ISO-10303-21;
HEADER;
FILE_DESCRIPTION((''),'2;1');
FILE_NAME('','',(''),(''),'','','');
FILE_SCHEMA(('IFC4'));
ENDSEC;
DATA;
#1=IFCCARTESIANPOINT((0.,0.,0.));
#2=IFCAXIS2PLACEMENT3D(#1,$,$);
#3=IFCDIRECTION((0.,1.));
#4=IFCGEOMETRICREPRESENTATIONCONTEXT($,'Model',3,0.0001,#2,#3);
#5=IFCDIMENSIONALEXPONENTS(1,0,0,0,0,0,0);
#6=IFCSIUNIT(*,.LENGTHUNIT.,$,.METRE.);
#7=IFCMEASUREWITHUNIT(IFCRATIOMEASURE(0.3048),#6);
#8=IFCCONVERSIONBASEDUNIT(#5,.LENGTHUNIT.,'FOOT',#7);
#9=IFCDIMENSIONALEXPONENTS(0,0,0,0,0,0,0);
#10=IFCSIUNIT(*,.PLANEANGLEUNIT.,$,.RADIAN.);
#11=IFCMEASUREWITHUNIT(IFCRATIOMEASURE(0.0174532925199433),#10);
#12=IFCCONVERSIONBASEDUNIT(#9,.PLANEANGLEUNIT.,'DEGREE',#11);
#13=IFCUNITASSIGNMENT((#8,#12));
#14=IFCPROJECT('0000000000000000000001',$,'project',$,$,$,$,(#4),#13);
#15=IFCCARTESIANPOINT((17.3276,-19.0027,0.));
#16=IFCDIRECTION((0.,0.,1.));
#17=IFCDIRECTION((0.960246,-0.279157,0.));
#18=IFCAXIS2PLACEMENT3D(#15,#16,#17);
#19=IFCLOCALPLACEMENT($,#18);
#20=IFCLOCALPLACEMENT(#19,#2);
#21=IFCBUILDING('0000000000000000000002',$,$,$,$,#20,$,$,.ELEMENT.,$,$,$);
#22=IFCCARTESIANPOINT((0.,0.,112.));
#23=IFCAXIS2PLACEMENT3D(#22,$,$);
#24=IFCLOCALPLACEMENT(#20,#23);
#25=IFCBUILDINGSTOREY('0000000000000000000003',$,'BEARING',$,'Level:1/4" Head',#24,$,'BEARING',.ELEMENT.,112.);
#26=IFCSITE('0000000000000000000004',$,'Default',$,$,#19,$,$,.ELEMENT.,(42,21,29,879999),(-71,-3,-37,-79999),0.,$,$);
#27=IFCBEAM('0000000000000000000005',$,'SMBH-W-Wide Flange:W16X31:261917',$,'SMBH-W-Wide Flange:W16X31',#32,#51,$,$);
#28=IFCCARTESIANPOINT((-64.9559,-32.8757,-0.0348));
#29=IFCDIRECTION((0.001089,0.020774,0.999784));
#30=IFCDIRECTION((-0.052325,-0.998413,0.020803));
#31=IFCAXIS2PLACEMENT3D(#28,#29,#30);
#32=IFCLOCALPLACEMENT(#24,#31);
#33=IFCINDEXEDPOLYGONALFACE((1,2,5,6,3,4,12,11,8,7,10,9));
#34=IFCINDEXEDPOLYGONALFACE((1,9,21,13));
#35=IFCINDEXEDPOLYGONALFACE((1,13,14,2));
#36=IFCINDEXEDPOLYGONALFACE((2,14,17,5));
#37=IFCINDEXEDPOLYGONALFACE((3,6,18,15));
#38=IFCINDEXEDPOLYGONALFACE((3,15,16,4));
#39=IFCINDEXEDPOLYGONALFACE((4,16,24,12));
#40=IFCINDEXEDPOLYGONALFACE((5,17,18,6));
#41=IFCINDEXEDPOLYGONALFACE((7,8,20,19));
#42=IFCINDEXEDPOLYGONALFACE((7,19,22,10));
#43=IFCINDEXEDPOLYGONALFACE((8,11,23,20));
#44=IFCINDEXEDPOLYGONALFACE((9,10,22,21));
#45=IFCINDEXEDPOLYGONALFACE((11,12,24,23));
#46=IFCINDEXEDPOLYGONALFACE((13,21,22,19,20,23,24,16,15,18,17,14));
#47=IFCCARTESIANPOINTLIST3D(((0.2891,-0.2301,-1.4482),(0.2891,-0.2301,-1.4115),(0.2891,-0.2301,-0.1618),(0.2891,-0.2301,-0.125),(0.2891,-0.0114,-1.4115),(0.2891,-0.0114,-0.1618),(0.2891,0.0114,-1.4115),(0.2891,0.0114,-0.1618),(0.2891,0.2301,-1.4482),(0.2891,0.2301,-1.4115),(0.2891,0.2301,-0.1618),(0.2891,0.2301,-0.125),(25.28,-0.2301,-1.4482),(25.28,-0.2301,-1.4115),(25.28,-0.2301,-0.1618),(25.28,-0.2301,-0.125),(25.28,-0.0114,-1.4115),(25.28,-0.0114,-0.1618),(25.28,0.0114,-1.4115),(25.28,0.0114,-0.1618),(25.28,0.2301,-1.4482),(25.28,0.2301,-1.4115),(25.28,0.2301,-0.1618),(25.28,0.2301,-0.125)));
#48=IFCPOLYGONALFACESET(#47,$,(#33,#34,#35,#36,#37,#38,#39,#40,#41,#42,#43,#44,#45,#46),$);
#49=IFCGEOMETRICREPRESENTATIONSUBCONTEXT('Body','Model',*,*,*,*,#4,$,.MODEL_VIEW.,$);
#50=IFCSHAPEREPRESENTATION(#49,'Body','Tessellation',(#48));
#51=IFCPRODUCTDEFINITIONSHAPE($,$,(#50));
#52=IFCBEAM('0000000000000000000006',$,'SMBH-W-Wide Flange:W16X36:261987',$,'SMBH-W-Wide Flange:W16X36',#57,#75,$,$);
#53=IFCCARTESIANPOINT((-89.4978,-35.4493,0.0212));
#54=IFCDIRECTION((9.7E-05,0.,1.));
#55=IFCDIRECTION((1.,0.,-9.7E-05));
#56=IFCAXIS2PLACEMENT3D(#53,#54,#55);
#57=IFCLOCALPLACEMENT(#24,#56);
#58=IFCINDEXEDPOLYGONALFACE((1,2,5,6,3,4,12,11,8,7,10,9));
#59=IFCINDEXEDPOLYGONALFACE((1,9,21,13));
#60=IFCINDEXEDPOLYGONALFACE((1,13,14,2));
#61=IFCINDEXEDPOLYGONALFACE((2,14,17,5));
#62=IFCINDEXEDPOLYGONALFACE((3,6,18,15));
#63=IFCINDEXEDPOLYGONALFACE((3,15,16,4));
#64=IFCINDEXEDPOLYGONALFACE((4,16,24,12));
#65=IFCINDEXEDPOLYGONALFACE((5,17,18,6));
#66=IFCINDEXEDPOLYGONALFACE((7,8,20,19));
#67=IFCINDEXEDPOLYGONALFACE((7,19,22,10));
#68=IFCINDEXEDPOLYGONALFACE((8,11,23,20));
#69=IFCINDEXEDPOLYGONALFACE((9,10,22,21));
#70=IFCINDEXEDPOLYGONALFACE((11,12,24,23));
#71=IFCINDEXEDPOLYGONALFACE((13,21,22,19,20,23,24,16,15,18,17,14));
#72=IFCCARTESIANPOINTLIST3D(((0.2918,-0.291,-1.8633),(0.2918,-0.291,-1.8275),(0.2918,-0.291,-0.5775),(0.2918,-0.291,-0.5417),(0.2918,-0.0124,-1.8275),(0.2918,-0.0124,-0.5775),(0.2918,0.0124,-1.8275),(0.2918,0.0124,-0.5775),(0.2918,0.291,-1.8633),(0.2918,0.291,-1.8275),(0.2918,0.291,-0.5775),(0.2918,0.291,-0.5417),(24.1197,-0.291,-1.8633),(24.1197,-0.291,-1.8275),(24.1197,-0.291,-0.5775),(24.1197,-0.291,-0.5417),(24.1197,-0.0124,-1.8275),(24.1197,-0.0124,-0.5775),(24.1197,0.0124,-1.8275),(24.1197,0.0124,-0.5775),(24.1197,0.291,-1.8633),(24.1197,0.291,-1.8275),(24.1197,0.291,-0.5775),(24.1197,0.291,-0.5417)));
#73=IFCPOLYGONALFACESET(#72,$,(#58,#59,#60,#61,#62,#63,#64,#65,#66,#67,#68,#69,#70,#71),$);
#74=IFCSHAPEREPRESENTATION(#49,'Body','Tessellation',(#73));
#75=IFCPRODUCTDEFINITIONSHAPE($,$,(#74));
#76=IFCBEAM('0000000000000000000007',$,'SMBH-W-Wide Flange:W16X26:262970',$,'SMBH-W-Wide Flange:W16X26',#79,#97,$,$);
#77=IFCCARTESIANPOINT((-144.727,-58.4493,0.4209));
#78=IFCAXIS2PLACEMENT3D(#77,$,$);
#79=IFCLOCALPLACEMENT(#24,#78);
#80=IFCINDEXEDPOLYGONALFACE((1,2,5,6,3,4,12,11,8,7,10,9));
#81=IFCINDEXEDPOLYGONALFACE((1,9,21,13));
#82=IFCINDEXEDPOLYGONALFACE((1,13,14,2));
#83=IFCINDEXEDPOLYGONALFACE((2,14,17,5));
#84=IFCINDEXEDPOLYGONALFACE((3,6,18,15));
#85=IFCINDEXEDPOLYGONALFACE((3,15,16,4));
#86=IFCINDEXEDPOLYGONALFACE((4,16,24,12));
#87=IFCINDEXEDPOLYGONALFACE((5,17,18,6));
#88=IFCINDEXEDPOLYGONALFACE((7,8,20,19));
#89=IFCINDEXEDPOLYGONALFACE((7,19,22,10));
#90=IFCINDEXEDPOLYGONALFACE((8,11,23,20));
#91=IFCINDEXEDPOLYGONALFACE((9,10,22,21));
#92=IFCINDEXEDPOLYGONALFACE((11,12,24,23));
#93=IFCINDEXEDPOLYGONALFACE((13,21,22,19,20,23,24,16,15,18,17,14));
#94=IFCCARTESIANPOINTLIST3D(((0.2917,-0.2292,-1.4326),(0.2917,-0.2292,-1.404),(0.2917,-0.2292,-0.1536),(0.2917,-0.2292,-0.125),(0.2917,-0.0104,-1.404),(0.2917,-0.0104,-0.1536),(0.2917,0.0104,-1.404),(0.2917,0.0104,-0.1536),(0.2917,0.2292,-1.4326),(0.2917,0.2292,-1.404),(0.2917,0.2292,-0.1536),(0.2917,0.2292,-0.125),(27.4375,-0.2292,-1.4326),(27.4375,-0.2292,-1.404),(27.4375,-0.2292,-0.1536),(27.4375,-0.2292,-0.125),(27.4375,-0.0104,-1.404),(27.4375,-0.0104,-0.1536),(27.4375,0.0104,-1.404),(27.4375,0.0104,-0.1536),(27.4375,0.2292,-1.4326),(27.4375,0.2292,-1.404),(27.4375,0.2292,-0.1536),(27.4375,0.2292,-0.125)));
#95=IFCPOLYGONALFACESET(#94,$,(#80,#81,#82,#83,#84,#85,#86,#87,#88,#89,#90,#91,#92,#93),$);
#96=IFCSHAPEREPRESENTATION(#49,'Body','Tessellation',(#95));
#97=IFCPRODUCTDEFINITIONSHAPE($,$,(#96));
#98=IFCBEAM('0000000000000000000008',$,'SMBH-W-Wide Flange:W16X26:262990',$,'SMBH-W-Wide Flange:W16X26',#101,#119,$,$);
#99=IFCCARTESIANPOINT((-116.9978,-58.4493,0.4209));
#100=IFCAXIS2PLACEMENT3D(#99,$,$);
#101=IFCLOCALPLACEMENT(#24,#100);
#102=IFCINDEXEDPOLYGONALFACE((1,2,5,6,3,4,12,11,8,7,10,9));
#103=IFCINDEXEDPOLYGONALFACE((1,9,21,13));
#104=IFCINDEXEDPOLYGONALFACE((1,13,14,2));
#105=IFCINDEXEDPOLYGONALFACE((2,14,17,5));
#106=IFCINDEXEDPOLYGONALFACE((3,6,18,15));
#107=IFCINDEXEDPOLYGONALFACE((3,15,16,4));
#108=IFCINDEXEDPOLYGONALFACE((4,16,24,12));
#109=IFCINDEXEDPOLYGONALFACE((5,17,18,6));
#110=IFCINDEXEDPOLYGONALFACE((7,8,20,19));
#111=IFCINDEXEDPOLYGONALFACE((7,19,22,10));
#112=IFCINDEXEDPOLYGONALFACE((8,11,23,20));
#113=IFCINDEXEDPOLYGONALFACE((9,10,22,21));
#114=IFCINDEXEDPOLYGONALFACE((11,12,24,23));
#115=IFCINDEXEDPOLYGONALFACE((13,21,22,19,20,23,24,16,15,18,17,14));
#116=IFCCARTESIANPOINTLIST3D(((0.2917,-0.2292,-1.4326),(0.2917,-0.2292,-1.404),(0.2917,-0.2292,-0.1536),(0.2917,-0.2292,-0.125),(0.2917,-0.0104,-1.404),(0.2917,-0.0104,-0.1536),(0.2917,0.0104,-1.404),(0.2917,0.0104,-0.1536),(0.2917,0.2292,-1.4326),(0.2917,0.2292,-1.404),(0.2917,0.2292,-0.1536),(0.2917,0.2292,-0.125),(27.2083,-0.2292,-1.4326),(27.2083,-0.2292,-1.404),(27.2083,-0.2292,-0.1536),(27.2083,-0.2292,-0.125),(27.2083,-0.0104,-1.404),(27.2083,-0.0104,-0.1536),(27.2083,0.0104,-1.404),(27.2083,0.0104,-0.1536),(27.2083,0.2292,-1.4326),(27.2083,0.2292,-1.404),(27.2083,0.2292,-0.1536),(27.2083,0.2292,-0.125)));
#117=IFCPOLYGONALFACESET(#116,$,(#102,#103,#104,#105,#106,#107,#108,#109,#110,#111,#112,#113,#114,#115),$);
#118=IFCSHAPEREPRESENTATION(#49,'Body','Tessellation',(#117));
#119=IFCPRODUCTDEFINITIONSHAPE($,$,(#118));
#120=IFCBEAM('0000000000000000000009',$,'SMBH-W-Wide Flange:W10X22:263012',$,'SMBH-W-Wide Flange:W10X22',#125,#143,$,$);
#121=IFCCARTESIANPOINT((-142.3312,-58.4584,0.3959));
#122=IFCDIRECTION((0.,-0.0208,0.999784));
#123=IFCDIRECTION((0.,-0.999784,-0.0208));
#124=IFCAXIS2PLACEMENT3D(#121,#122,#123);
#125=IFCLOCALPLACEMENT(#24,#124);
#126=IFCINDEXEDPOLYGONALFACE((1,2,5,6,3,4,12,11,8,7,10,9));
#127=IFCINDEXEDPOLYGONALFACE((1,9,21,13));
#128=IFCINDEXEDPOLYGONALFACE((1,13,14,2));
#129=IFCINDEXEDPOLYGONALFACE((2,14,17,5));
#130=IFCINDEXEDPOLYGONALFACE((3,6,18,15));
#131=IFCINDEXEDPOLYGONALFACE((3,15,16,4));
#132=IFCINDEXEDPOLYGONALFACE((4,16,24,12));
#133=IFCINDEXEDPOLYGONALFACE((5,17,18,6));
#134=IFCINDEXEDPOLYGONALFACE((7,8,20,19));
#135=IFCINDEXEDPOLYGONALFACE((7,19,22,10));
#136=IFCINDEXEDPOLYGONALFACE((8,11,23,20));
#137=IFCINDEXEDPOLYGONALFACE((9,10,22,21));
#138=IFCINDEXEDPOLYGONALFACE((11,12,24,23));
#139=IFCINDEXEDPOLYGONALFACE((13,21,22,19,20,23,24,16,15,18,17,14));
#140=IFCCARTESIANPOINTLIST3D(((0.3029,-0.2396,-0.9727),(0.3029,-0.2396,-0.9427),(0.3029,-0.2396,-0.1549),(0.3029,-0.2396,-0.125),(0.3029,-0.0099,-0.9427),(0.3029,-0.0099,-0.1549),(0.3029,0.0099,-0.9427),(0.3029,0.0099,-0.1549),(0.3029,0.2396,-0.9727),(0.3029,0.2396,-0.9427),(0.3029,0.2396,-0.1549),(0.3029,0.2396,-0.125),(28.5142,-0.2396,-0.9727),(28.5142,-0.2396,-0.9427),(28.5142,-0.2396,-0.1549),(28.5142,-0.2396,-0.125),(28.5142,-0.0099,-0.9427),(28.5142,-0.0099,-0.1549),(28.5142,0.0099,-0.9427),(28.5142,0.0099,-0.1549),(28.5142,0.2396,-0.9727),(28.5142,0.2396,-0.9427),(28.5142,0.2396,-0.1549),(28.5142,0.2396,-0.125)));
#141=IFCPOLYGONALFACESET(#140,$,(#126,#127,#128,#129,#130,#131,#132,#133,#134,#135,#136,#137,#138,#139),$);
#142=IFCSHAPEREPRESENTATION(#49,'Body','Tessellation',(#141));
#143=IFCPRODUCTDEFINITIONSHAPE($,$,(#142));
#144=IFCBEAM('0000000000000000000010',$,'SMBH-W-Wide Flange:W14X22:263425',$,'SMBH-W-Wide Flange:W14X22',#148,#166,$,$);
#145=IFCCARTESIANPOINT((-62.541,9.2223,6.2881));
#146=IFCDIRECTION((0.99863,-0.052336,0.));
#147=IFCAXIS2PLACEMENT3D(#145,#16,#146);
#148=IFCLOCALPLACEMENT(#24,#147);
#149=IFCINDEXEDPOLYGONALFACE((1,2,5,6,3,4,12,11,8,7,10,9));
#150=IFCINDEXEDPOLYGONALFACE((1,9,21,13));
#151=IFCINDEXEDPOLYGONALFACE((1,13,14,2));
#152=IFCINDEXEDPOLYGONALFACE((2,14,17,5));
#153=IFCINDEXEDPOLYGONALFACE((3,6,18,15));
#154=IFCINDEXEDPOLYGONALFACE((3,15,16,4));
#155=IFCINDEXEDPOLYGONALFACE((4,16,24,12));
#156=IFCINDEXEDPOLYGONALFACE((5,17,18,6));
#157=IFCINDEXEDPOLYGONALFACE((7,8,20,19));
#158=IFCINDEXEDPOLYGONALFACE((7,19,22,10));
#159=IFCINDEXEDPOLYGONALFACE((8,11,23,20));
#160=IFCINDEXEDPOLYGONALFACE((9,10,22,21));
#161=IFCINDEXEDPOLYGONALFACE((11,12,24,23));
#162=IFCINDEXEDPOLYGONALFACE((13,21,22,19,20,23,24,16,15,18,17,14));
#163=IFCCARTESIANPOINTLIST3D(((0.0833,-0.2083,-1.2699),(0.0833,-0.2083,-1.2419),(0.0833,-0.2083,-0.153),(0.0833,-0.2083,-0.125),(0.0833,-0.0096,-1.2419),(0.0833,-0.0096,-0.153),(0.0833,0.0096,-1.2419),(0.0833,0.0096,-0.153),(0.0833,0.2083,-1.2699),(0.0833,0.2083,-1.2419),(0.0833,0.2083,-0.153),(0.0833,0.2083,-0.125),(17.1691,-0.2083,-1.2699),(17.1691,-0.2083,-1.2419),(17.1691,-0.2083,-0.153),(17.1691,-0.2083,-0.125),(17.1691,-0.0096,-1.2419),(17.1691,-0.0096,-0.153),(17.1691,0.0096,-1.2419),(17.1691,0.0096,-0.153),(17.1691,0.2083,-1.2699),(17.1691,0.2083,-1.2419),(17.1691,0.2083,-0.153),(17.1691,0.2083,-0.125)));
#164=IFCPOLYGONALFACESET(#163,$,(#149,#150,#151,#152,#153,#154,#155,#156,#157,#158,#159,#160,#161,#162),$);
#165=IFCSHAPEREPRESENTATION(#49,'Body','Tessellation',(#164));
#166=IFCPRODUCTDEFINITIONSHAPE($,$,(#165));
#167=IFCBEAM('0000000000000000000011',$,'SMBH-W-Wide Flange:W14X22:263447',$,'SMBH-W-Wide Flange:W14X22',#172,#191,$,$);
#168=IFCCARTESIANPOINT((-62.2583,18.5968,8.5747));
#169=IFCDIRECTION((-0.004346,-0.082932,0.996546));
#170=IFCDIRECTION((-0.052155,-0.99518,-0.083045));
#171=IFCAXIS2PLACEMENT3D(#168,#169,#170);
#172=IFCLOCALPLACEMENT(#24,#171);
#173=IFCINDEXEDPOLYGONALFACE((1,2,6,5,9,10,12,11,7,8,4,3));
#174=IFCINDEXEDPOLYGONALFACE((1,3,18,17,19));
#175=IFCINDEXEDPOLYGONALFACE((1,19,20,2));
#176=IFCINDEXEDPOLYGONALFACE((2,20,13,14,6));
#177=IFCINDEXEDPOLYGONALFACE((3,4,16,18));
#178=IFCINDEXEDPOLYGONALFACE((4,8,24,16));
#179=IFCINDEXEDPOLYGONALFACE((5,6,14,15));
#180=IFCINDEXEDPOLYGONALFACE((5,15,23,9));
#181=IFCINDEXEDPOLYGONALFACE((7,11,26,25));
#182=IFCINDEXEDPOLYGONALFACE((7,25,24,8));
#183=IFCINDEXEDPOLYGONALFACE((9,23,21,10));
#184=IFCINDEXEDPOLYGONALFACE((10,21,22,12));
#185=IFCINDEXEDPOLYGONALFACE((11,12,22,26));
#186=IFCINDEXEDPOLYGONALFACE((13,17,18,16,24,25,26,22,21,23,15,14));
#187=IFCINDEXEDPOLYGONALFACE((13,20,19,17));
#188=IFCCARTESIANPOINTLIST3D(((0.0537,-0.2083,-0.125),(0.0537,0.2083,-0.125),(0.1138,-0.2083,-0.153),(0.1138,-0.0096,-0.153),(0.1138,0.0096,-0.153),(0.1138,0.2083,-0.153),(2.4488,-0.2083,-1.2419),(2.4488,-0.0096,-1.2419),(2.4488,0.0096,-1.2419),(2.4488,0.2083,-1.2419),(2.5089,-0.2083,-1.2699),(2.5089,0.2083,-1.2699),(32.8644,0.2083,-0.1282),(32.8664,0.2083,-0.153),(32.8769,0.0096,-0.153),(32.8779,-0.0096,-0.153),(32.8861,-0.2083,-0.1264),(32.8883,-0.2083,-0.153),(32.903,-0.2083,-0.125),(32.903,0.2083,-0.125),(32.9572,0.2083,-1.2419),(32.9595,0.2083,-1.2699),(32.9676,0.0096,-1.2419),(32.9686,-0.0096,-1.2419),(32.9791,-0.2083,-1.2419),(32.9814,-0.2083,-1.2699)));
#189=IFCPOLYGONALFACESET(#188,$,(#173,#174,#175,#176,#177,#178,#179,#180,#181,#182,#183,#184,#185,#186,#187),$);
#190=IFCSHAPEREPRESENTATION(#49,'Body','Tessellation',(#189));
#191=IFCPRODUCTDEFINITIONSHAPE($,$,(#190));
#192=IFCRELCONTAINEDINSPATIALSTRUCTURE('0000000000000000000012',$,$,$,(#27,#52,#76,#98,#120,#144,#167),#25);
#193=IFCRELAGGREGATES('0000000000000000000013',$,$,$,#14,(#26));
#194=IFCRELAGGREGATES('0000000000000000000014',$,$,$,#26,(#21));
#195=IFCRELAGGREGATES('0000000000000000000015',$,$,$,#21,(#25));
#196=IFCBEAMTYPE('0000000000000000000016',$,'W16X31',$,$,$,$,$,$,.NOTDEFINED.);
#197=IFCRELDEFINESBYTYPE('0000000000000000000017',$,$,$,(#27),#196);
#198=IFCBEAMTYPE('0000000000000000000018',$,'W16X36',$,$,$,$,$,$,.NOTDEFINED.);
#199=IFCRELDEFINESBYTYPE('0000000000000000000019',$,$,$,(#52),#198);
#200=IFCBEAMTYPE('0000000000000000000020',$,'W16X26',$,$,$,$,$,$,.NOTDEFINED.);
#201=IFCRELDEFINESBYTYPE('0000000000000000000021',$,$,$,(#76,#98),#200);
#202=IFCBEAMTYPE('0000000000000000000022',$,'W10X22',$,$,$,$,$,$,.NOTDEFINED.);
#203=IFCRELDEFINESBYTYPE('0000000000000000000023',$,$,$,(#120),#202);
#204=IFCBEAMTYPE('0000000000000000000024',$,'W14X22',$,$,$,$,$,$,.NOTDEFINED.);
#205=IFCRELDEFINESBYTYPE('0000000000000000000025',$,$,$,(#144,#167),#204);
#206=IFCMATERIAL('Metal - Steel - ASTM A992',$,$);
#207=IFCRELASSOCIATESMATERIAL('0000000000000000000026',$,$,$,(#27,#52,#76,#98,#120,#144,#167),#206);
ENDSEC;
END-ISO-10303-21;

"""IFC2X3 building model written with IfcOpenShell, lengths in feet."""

from ifc_helpers import new_model, entity, si_unit, converted_unit, direction, frame, frame_2d, origin, place, context, subcontext, project, spatial, polyline, i_section, outline, extrude, clip, halfspace, bounded_halfspace, material, type_object, element, save


model = new_model("IFC2X3")

# Units and contexts
model_context = context("Model", 3, precision=0.0001, world=origin(), true_north=direction((0.0, 1.0)))
body_context = subcontext(model_context, "Body", "Model", "MODEL_VIEW")
ifc_project = project(units=[converted_unit("LENGTHUNIT", "FOOT", entity("IfcRatioMeasure", 0.3048), si_unit("LENGTHUNIT", "METRE"), dimensions=[1, 0, 0, 0, 0, 0, 0]), converted_unit("PLANEANGLEUNIT", "DEGREE", entity("IfcRatioMeasure", 0.0174532925199433), si_unit("PLANEANGLEUNIT", "RADIAN"), dimensions=[0, 0, 0, 0, 0, 0, 0])], contexts=[model_context])

# Site, building, storey
site_placement = place(None, frame((17.3276, -19.0027, 0.0), z_axis=(0.0, 0.0, 1.0), x_axis=(0.960246, -0.279157, 0.0)))
site = spatial("IfcSite", under=ifc_project, at=site_placement, Name="Default", CompositionType="ELEMENT", RefLatitude=(42, 21, 29, 879999), RefLongitude=(-71, -3, -37, -79999), RefElevation=0.0)
building_placement = place(site_placement, origin())
building = spatial("IfcBuilding", under=site, at=building_placement, CompositionType="ELEMENT")
storey_placement = place(building_placement, frame((0.0, 0.0, 112.0)))
storey = spatial("IfcBuildingStorey", under=building, at=storey_placement, Name="BEARING", ObjectType="Level:1/4\" Head", LongName="BEARING", CompositionType="ELEMENT", Elevation=112.0)

# Beams
ifc_material_1 = material(Name="Metal - Steel - ASTM A992")
beam_type_1 = type_object("IfcBeamType", Name="W16X31", PredefinedType="NOTDEFINED")
beam_1_placement = place(storey_placement, frame((-64.9559, -32.8757, -0.0348), z_axis=(0.001089, 0.020774, 0.999784), x_axis=(-0.052325, -0.998413, 0.020803)))
element("IfcBeam", 1, at=beam_1_placement, inside=storey, type_object=beam_type_1, material=ifc_material_1, Name="SMBH-W-Wide Flange:W16X31:261917", ObjectType="SMBH-W-Wide Flange:W16X31", context=body_context, shape_type="SweptSolid", body=[
    extrude(i_section(OverallWidth=0.4603, OverallDepth=1.3232, WebThickness=0.0228, FlangeThickness=0.0368, at=frame_2d((0.0, 0.0), x_axis=(0.0, 1.0))), frame((0.2891, 0.0, -0.7866), z_axis=(1.0, 0.0, 0.0), x_axis=(0.0, 0.0, -1.0)), (0.0, 0.0, 1.0), 24.9909),
])
beam_type_2 = type_object("IfcBeamType", Name="W16X36", PredefinedType="NOTDEFINED")
beam_2_placement = place(storey_placement, frame((-89.4978, -35.4493, 0.0212), z_axis=(0.000097, 0.0, 1.0), x_axis=(1.0, 0.0, -0.000097)))
element("IfcBeam", 2, at=beam_2_placement, inside=storey, type_object=beam_type_2, material=ifc_material_1, Name="SMBH-W-Wide Flange:W16X36:261987", ObjectType="SMBH-W-Wide Flange:W16X36", context=body_context, shape_type="SweptSolid", body=[
    extrude(i_section(OverallWidth=0.582, OverallDepth=1.3216, WebThickness=0.0247, FlangeThickness=0.0358, at=frame_2d((0.0, 0.0), x_axis=(0.0, 1.0))), frame((0.2918, 0.0, -1.2025), z_axis=(1.0, 0.0, 0.0), x_axis=(0.0, 0.0, -1.0)), (0.0, 0.0, 1.0), 23.8279),
])
beam_type_3 = type_object("IfcBeamType", Name="W16X26", PredefinedType="NOTDEFINED")
beam_3_placement = place(storey_placement, frame((-144.727, -58.4493, 0.4209)))
element("IfcBeam", 3, at=beam_3_placement, inside=storey, type_object=beam_type_3, material=ifc_material_1, Name="SMBH-W-Wide Flange:W16X26:262970", ObjectType="SMBH-W-Wide Flange:W16X26", context=body_context, shape_type="SweptSolid", body=[
    extrude(i_section(OverallWidth=0.4583, OverallDepth=1.3076, WebThickness=0.0208, FlangeThickness=0.0286, at=frame_2d((0.0, 0.0), x_axis=(0.0, 1.0))), frame((0.2917, 0.0, -0.7788), z_axis=(1.0, 0.0, 0.0), x_axis=(0.0, 0.0, -1.0)), (0.0, 0.0, 1.0), 27.1458),
])
beam_4_placement = place(storey_placement, frame((-116.9978, -58.4493, 0.4209)))
element("IfcBeam", 4, at=beam_4_placement, inside=storey, type_object=beam_type_3, material=ifc_material_1, Name="SMBH-W-Wide Flange:W16X26:262990", ObjectType="SMBH-W-Wide Flange:W16X26", context=body_context, shape_type="SweptSolid", body=[
    extrude(i_section(OverallWidth=0.4583, OverallDepth=1.3076, WebThickness=0.0208, FlangeThickness=0.0286, at=frame_2d((0.0, 0.0), x_axis=(0.0, 1.0))), frame((0.2917, 0.0, -0.7788), z_axis=(1.0, 0.0, 0.0), x_axis=(0.0, 0.0, -1.0)), (0.0, 0.0, 1.0), 26.9167),
])
beam_type_4 = type_object("IfcBeamType", Name="W10X22", PredefinedType="NOTDEFINED")
beam_5_placement = place(storey_placement, frame((-142.3312, -58.4584, 0.3959), z_axis=(0.0, -0.0208, 0.999784), x_axis=(0.0, -0.999784, -0.0208)))
element("IfcBeam", 5, at=beam_5_placement, inside=storey, type_object=beam_type_4, material=ifc_material_1, Name="SMBH-W-Wide Flange:W10X22:263012", ObjectType="SMBH-W-Wide Flange:W10X22", context=body_context, shape_type="SweptSolid", body=[
    extrude(i_section(OverallWidth=0.4792, OverallDepth=0.8477, WebThickness=0.0199, FlangeThickness=0.0299, at=frame_2d((0.0, 0.0), x_axis=(0.0, 1.0))), frame((0.3029, 0.0, -0.5488), z_axis=(1.0, 0.0, 0.0), x_axis=(0.0, 0.0, -1.0)), (0.0, 0.0, 1.0), 28.2113),
])
beam_type_5 = type_object("IfcBeamType", Name="W14X22", PredefinedType="NOTDEFINED")
beam_6_placement = place(storey_placement, frame((-62.541, 9.2223, 6.2881), z_axis=(0.0, 0.0, 1.0), x_axis=(0.99863, -0.052336, 0.0)))
element("IfcBeam", 6, at=beam_6_placement, inside=storey, type_object=beam_type_5, material=ifc_material_1, Name="SMBH-W-Wide Flange:W14X22:263425", ObjectType="SMBH-W-Wide Flange:W14X22", context=body_context, shape_type="SweptSolid", body=[
    extrude(i_section(OverallWidth=0.4167, OverallDepth=1.1449, WebThickness=0.0192, FlangeThickness=0.028, at=frame_2d((0.0, 0.0), x_axis=(0.0, 1.0))), frame((0.0833, 0.0, -0.6974), z_axis=(1.0, 0.0, 0.0), x_axis=(0.0, 0.0, -1.0)), (0.0, 0.0, 1.0), 17.0857),
])
beam_7_placement = place(storey_placement, frame((-62.2583, 18.5968, 8.5747), z_axis=(-0.004346, -0.082932, 0.996546), x_axis=(-0.052155, -0.99518, -0.083045)))
element("IfcBeam", 7, at=beam_7_placement, inside=storey, type_object=beam_type_5, material=ifc_material_1, Name="SMBH-W-Wide Flange:W14X22:263447", ObjectType="SMBH-W-Wide Flange:W14X22", context=body_context, shape_type="SweptSolid", body=[
    clip(clip(clip(extrude(outline(polyline([(-0.2083, -0.5444), (-0.2083, -0.5724), (0.2083, -0.5724), (0.2083, -0.5444), (0.0096, -0.5444), (0.0096, 0.5444), (0.2083, 0.5444), (0.2083, 0.5724), (-0.2083, 0.5724), (-0.2083, 0.5444), (-0.0096, 0.5444), (-0.0096, -0.5444), (-0.2083, -0.5444)])), frame((0.0537, 0.0, -0.6974), z_axis=(-1.0, 0.0, 0.0), x_axis=(0.0, 1.0, 0.0)), (0.0, 0.0, -1.0), 32.9277), halfspace(frame((2.5089, -33.241, -1.2699), z_axis=(-0.422622, 0.0, -0.906306), x_axis=(0.0, 1.0, 0.0)), False)), bounded_halfspace(frame((33.1663, 0.0, -0.1031), z_axis=(0.083045, 0.0, -0.996546), x_axis=(-0.052155, 0.99863, -0.004346)), False, frame((0.0537, 0.0, -0.6974), z_axis=(-1.0, 0.0, 0.0), x_axis=(0.0, 1.0, 0.0)), polyline([(-0.2083, -0.571), (0.2083, -0.5692), (0.2083, -0.5724), (-0.2083, -0.5724), (-0.2083, -0.571)]))), bounded_halfspace(frame((34.3661, -0.3065, -17.8239), z_axis=(0.99518, 0.052336, 0.082932), x_axis=(-0.083045, 0.0, 0.996546)), False, frame((0.0537, 0.0, -0.6974), z_axis=(-1.0, 0.0, 0.0), x_axis=(0.0, 1.0, 0.0)), polyline([(0.2083, -0.5692), (-0.2083, -0.571), (-0.2083, -0.5444), (-0.0096, -0.5444), (-0.0096, 0.5444), (-0.2083, 0.5444), (-0.2083, 0.5724), (0.2083, 0.5724), (0.2083, 0.5444), (0.0096, 0.5444), (0.0096, -0.5444), (0.2083, -0.5444), (0.2083, -0.5692)]))),
])

save(model, "model.ifc")
